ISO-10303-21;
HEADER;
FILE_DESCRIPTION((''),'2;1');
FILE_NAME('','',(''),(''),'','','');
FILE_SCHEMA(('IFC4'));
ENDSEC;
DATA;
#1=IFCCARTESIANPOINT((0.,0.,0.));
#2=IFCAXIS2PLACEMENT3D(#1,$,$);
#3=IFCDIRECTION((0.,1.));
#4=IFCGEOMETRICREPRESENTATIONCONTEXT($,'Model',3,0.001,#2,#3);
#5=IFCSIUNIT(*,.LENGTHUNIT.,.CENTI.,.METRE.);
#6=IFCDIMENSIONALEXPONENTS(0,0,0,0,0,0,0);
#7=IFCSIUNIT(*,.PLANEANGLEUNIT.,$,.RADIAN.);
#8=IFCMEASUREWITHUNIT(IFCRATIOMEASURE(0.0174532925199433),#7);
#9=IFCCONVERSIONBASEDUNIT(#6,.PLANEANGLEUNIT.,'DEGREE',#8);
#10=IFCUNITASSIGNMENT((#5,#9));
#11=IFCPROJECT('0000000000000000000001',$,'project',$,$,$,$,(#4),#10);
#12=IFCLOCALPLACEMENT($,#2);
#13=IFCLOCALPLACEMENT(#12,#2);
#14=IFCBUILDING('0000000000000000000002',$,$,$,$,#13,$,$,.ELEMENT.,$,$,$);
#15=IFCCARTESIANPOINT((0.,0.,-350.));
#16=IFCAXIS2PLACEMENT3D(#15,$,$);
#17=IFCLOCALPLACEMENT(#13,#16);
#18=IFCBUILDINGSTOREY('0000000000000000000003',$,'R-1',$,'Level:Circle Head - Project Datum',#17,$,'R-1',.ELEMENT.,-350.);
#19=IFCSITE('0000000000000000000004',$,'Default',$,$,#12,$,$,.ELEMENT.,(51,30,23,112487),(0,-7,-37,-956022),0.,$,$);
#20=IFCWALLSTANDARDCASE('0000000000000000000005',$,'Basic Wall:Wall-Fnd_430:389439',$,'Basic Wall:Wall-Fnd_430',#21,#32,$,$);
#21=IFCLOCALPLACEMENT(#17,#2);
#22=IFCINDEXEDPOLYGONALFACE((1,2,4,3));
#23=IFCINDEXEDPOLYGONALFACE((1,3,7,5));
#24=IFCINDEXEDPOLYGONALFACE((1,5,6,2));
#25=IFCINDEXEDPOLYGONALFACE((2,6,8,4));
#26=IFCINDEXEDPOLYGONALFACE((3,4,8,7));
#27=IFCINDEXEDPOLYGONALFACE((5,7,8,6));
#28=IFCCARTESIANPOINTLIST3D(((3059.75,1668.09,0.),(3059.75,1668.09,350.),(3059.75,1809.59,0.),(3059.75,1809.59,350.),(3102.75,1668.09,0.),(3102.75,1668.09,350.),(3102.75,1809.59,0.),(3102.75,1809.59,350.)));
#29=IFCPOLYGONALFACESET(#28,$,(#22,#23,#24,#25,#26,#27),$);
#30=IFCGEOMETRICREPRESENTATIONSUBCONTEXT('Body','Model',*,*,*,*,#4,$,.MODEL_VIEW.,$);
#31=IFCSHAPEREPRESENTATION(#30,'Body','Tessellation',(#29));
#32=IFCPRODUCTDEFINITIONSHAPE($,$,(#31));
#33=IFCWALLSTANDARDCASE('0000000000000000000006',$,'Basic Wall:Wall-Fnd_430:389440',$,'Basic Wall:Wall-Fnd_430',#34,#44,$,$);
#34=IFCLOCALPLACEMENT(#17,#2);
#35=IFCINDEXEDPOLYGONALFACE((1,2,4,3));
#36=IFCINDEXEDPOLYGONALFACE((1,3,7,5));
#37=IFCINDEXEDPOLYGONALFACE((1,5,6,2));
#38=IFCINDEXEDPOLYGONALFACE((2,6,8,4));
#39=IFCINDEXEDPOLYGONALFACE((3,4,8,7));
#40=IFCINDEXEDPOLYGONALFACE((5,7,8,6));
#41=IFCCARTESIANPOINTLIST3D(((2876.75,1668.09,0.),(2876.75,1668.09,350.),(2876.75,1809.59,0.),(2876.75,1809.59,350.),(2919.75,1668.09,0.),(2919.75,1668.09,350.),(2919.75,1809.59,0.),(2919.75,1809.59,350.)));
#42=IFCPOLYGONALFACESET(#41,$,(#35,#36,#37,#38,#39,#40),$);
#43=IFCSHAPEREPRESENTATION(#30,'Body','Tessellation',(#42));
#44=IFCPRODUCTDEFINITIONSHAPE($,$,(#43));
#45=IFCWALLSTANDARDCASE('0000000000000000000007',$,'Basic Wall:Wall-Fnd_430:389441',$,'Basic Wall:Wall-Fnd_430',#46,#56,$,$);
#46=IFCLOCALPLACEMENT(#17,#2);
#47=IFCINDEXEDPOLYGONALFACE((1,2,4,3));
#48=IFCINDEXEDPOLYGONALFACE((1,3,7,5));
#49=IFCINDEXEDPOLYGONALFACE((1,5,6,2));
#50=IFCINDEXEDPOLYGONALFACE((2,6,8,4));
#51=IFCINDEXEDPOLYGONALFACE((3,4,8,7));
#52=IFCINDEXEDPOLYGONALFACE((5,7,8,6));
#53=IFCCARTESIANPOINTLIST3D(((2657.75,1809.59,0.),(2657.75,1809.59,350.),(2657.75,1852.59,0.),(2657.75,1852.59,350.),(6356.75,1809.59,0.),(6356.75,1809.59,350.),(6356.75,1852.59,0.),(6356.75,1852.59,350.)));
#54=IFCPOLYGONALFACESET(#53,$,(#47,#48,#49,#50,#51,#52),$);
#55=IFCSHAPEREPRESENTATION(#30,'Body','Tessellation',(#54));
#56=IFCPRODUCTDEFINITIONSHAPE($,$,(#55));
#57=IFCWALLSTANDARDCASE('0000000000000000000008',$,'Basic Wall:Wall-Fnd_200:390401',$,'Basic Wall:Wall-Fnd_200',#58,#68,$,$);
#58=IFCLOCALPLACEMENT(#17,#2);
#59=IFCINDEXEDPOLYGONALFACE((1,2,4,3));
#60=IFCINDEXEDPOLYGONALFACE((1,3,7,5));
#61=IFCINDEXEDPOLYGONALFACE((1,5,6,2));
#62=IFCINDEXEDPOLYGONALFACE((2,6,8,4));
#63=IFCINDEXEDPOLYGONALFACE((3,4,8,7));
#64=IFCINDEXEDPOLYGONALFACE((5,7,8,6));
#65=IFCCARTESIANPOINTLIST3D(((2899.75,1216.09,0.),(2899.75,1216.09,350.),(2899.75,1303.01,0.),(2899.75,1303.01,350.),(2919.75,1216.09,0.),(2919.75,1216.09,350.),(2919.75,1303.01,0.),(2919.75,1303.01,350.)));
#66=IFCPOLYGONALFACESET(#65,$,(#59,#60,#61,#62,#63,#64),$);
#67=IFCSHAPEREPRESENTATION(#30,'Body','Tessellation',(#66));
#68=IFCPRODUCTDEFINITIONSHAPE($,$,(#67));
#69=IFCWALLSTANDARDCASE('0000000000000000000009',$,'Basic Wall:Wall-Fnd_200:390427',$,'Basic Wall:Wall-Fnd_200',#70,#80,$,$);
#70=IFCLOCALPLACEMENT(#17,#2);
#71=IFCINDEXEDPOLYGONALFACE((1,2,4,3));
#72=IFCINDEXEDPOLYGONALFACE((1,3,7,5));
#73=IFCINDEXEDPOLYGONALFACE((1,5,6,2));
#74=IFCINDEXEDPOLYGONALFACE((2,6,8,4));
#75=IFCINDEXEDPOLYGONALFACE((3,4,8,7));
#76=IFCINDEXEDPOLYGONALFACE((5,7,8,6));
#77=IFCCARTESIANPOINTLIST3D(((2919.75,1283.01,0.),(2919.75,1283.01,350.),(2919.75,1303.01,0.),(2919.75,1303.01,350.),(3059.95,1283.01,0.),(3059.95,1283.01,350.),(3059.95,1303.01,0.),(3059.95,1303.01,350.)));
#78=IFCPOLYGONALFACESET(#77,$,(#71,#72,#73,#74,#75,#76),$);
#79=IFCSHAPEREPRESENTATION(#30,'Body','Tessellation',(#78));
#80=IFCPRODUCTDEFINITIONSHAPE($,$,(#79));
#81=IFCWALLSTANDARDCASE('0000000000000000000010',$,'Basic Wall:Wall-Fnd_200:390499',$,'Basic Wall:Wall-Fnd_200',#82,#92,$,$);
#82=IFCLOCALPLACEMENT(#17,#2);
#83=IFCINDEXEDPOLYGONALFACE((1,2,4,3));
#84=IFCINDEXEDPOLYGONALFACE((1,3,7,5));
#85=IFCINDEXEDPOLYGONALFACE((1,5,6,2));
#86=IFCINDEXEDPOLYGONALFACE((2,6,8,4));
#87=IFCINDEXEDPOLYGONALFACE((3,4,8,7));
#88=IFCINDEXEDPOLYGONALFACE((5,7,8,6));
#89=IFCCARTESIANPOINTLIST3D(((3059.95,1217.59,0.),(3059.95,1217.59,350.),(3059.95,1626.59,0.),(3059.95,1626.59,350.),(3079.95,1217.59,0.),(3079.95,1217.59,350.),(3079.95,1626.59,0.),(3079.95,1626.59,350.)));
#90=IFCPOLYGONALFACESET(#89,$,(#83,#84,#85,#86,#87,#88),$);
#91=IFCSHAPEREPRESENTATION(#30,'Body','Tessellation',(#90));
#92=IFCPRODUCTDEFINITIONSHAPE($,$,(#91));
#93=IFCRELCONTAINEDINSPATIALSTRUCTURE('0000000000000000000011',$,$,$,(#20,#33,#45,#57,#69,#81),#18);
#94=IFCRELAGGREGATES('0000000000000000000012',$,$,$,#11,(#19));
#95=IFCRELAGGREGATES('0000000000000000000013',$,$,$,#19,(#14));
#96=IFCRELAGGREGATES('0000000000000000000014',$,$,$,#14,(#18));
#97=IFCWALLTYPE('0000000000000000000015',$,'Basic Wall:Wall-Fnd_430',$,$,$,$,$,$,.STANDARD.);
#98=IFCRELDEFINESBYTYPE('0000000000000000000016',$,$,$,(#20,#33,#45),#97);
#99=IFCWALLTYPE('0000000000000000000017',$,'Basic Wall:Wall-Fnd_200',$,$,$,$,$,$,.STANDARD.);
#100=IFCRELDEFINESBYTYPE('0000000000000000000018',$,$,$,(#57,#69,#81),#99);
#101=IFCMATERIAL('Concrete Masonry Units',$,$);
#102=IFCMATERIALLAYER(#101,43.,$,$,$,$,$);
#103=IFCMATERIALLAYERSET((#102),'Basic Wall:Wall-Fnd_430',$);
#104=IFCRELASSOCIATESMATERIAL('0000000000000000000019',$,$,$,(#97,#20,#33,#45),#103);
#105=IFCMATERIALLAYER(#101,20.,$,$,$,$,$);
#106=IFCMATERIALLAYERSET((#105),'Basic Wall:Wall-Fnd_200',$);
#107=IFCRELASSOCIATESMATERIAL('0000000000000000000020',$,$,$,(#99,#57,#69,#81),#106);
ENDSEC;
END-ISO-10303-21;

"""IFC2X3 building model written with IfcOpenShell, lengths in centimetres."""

from ifc_helpers import new_model, entity, si_unit, converted_unit, direction, frame, frame_2d, origin, place, context, subcontext, project, spatial, rectangle, extrude, material, layer, layer_set, layer_usage, type_object, element, save


model = new_model("IFC2X3")

# Units and contexts
model_context = context("Model", 3, precision=0.001, world=origin(), true_north=direction((0.0, 1.0)))
body_context = subcontext(model_context, "Body", "Model", "MODEL_VIEW")
ifc_project = project(units=[si_unit("LENGTHUNIT", "METRE", prefix="CENTI"), converted_unit("PLANEANGLEUNIT", "DEGREE", entity("IfcRatioMeasure", 0.0174532925199433), si_unit("PLANEANGLEUNIT", "RADIAN"), dimensions=[0, 0, 0, 0, 0, 0, 0])], contexts=[model_context])

# Site, building, storey
site_placement = place(None, origin())
site = spatial("IfcSite", under=ifc_project, at=site_placement, Name="Default", CompositionType="ELEMENT", RefLatitude=(51, 30, 23, 112487), RefLongitude=(0, -7, -37, -956022), RefElevation=0.0)
building_placement = place(site_placement, origin())
building = spatial("IfcBuilding", under=site, at=building_placement, CompositionType="ELEMENT")
storey_placement = place(building_placement, frame((0.0, 0.0, -350.0)))
storey = spatial("IfcBuildingStorey", under=building, at=storey_placement, Name="R-1", ObjectType="Level:Circle Head - Project Datum", LongName="R-1", CompositionType="ELEMENT", Elevation=-350.0)

# Walls
ifc_material_1 = material(Name="Concrete Masonry Units")
ifc_layer_1 = layer(ifc_material_1, 43.0)
ifc_layer_set_1 = layer_set([ifc_layer_1], Name="Basic Wall:Wall-Fnd_430")
wall_type_1 = type_object("IfcWallType", Name="Basic Wall:Wall-Fnd_430", PredefinedType="STANDARD", material=ifc_layer_set_1)
ifc_layer_usage_1 = layer_usage(ifc_layer_set_1, "AXIS2", "POSITIVE", -21.5)
wall_1_placement = place(storey_placement, frame((3081.25, 1809.59, 0.0), z_axis=(0.0, 0.0, 1.0), x_axis=(0.0, -1.0, 0.0)))
element("IfcWallStandardCase", 1, at=wall_1_placement, inside=storey, type_object=wall_type_1, material=ifc_layer_usage_1, Name="Basic Wall:Wall-Fnd_430:389439", ObjectType="Basic Wall:Wall-Fnd_430", context=body_context, shape_type="SweptSolid", body=[
    extrude(rectangle(XDim=141.5, YDim=43.0, at=frame_2d((70.75, 0.0), x_axis=(-1.0, 0.0))), origin(), (0.0, 0.0, 1.0), 350.0),
])
ifc_layer_usage_2 = layer_usage(ifc_layer_set_1, "AXIS2", "POSITIVE", -21.5)
wall_2_placement = place(storey_placement, frame((2898.25, 1809.59, 0.0), z_axis=(0.0, 0.0, 1.0), x_axis=(0.0, -1.0, 0.0)))
element("IfcWallStandardCase", 2, at=wall_2_placement, inside=storey, type_object=wall_type_1, material=ifc_layer_usage_2, Name="Basic Wall:Wall-Fnd_430:389440", ObjectType="Basic Wall:Wall-Fnd_430", context=body_context, shape_type="SweptSolid", body=[
    extrude(rectangle(XDim=141.5, YDim=43.0, at=frame_2d((70.75, 0.0), x_axis=(-1.0, 0.0))), origin(), (0.0, 0.0, 1.0), 350.0),
])
ifc_layer_usage_3 = layer_usage(ifc_layer_set_1, "AXIS2", "POSITIVE", -21.5)
wall_3_placement = place(storey_placement, frame((2657.75, 1831.09, 0.0)))
element("IfcWallStandardCase", 3, at=wall_3_placement, inside=storey, type_object=wall_type_1, material=ifc_layer_usage_3, Name="Basic Wall:Wall-Fnd_430:389441", ObjectType="Basic Wall:Wall-Fnd_430", context=body_context, shape_type="SweptSolid", body=[
    extrude(rectangle(XDim=3699.0, YDim=43.0, at=frame_2d((1849.5, 0.0), x_axis=(-1.0, 0.0))), origin(), (0.0, 0.0, 1.0), 350.0),
])
ifc_layer_2 = layer(ifc_material_1, 20.0)
ifc_layer_set_2 = layer_set([ifc_layer_2], Name="Basic Wall:Wall-Fnd_200")
ifc_layer_usage_4 = layer_usage(ifc_layer_set_2, "AXIS2", "POSITIVE", -10.0)
wall_type_2 = type_object("IfcWallType", Name="Basic Wall:Wall-Fnd_200", PredefinedType="STANDARD", material=ifc_layer_set_2)
wall_4_placement = place(storey_placement, frame((2909.75, 1216.09, 0.0), z_axis=(0.0, 0.0, 1.0), x_axis=(0.0, 1.0, 0.0)))
element("IfcWallStandardCase", 4, at=wall_4_placement, inside=storey, type_object=wall_type_2, material=ifc_layer_usage_4, Name="Basic Wall:Wall-Fnd_200:390401", ObjectType="Basic Wall:Wall-Fnd_200", context=body_context, shape_type="SweptSolid", body=[
    extrude(rectangle(XDim=86.92, YDim=20.0, at=frame_2d((43.46, 0.0), x_axis=(-1.0, 0.0))), origin(), (0.0, 0.0, 1.0), 350.0),
])
ifc_layer_usage_5 = layer_usage(ifc_layer_set_2, "AXIS2", "POSITIVE", -10.0)
wall_5_placement = place(storey_placement, frame((2919.75, 1293.01, 0.0)))
element("IfcWallStandardCase", 5, at=wall_5_placement, inside=storey, type_object=wall_type_2, material=ifc_layer_usage_5, Name="Basic Wall:Wall-Fnd_200:390427", ObjectType="Basic Wall:Wall-Fnd_200", context=body_context, shape_type="SweptSolid", body=[
    extrude(rectangle(XDim=140.2, YDim=20.0, at=frame_2d((70.1, 0.0), x_axis=(-1.0, 0.0))), origin(), (0.0, 0.0, 1.0), 350.0),
])
ifc_layer_usage_6 = layer_usage(ifc_layer_set_2, "AXIS2", "NEGATIVE", 10.0)
wall_6_placement = place(storey_placement, frame((3069.95, 1217.59, 0.0), z_axis=(0.0, 0.0, 1.0), x_axis=(0.0, 1.0, 0.0)))
element("IfcWallStandardCase", 6, at=wall_6_placement, inside=storey, type_object=wall_type_2, material=ifc_layer_usage_6, Name="Basic Wall:Wall-Fnd_200:390499", ObjectType="Basic Wall:Wall-Fnd_200", context=body_context, shape_type="SweptSolid", body=[
    extrude(rectangle(XDim=409.0, YDim=20.0, at=frame_2d((204.5, 0.0), x_axis=(-1.0, 0.0))), origin(), (0.0, 0.0, 1.0), 350.0),
])

save(model, "model.ifc")
